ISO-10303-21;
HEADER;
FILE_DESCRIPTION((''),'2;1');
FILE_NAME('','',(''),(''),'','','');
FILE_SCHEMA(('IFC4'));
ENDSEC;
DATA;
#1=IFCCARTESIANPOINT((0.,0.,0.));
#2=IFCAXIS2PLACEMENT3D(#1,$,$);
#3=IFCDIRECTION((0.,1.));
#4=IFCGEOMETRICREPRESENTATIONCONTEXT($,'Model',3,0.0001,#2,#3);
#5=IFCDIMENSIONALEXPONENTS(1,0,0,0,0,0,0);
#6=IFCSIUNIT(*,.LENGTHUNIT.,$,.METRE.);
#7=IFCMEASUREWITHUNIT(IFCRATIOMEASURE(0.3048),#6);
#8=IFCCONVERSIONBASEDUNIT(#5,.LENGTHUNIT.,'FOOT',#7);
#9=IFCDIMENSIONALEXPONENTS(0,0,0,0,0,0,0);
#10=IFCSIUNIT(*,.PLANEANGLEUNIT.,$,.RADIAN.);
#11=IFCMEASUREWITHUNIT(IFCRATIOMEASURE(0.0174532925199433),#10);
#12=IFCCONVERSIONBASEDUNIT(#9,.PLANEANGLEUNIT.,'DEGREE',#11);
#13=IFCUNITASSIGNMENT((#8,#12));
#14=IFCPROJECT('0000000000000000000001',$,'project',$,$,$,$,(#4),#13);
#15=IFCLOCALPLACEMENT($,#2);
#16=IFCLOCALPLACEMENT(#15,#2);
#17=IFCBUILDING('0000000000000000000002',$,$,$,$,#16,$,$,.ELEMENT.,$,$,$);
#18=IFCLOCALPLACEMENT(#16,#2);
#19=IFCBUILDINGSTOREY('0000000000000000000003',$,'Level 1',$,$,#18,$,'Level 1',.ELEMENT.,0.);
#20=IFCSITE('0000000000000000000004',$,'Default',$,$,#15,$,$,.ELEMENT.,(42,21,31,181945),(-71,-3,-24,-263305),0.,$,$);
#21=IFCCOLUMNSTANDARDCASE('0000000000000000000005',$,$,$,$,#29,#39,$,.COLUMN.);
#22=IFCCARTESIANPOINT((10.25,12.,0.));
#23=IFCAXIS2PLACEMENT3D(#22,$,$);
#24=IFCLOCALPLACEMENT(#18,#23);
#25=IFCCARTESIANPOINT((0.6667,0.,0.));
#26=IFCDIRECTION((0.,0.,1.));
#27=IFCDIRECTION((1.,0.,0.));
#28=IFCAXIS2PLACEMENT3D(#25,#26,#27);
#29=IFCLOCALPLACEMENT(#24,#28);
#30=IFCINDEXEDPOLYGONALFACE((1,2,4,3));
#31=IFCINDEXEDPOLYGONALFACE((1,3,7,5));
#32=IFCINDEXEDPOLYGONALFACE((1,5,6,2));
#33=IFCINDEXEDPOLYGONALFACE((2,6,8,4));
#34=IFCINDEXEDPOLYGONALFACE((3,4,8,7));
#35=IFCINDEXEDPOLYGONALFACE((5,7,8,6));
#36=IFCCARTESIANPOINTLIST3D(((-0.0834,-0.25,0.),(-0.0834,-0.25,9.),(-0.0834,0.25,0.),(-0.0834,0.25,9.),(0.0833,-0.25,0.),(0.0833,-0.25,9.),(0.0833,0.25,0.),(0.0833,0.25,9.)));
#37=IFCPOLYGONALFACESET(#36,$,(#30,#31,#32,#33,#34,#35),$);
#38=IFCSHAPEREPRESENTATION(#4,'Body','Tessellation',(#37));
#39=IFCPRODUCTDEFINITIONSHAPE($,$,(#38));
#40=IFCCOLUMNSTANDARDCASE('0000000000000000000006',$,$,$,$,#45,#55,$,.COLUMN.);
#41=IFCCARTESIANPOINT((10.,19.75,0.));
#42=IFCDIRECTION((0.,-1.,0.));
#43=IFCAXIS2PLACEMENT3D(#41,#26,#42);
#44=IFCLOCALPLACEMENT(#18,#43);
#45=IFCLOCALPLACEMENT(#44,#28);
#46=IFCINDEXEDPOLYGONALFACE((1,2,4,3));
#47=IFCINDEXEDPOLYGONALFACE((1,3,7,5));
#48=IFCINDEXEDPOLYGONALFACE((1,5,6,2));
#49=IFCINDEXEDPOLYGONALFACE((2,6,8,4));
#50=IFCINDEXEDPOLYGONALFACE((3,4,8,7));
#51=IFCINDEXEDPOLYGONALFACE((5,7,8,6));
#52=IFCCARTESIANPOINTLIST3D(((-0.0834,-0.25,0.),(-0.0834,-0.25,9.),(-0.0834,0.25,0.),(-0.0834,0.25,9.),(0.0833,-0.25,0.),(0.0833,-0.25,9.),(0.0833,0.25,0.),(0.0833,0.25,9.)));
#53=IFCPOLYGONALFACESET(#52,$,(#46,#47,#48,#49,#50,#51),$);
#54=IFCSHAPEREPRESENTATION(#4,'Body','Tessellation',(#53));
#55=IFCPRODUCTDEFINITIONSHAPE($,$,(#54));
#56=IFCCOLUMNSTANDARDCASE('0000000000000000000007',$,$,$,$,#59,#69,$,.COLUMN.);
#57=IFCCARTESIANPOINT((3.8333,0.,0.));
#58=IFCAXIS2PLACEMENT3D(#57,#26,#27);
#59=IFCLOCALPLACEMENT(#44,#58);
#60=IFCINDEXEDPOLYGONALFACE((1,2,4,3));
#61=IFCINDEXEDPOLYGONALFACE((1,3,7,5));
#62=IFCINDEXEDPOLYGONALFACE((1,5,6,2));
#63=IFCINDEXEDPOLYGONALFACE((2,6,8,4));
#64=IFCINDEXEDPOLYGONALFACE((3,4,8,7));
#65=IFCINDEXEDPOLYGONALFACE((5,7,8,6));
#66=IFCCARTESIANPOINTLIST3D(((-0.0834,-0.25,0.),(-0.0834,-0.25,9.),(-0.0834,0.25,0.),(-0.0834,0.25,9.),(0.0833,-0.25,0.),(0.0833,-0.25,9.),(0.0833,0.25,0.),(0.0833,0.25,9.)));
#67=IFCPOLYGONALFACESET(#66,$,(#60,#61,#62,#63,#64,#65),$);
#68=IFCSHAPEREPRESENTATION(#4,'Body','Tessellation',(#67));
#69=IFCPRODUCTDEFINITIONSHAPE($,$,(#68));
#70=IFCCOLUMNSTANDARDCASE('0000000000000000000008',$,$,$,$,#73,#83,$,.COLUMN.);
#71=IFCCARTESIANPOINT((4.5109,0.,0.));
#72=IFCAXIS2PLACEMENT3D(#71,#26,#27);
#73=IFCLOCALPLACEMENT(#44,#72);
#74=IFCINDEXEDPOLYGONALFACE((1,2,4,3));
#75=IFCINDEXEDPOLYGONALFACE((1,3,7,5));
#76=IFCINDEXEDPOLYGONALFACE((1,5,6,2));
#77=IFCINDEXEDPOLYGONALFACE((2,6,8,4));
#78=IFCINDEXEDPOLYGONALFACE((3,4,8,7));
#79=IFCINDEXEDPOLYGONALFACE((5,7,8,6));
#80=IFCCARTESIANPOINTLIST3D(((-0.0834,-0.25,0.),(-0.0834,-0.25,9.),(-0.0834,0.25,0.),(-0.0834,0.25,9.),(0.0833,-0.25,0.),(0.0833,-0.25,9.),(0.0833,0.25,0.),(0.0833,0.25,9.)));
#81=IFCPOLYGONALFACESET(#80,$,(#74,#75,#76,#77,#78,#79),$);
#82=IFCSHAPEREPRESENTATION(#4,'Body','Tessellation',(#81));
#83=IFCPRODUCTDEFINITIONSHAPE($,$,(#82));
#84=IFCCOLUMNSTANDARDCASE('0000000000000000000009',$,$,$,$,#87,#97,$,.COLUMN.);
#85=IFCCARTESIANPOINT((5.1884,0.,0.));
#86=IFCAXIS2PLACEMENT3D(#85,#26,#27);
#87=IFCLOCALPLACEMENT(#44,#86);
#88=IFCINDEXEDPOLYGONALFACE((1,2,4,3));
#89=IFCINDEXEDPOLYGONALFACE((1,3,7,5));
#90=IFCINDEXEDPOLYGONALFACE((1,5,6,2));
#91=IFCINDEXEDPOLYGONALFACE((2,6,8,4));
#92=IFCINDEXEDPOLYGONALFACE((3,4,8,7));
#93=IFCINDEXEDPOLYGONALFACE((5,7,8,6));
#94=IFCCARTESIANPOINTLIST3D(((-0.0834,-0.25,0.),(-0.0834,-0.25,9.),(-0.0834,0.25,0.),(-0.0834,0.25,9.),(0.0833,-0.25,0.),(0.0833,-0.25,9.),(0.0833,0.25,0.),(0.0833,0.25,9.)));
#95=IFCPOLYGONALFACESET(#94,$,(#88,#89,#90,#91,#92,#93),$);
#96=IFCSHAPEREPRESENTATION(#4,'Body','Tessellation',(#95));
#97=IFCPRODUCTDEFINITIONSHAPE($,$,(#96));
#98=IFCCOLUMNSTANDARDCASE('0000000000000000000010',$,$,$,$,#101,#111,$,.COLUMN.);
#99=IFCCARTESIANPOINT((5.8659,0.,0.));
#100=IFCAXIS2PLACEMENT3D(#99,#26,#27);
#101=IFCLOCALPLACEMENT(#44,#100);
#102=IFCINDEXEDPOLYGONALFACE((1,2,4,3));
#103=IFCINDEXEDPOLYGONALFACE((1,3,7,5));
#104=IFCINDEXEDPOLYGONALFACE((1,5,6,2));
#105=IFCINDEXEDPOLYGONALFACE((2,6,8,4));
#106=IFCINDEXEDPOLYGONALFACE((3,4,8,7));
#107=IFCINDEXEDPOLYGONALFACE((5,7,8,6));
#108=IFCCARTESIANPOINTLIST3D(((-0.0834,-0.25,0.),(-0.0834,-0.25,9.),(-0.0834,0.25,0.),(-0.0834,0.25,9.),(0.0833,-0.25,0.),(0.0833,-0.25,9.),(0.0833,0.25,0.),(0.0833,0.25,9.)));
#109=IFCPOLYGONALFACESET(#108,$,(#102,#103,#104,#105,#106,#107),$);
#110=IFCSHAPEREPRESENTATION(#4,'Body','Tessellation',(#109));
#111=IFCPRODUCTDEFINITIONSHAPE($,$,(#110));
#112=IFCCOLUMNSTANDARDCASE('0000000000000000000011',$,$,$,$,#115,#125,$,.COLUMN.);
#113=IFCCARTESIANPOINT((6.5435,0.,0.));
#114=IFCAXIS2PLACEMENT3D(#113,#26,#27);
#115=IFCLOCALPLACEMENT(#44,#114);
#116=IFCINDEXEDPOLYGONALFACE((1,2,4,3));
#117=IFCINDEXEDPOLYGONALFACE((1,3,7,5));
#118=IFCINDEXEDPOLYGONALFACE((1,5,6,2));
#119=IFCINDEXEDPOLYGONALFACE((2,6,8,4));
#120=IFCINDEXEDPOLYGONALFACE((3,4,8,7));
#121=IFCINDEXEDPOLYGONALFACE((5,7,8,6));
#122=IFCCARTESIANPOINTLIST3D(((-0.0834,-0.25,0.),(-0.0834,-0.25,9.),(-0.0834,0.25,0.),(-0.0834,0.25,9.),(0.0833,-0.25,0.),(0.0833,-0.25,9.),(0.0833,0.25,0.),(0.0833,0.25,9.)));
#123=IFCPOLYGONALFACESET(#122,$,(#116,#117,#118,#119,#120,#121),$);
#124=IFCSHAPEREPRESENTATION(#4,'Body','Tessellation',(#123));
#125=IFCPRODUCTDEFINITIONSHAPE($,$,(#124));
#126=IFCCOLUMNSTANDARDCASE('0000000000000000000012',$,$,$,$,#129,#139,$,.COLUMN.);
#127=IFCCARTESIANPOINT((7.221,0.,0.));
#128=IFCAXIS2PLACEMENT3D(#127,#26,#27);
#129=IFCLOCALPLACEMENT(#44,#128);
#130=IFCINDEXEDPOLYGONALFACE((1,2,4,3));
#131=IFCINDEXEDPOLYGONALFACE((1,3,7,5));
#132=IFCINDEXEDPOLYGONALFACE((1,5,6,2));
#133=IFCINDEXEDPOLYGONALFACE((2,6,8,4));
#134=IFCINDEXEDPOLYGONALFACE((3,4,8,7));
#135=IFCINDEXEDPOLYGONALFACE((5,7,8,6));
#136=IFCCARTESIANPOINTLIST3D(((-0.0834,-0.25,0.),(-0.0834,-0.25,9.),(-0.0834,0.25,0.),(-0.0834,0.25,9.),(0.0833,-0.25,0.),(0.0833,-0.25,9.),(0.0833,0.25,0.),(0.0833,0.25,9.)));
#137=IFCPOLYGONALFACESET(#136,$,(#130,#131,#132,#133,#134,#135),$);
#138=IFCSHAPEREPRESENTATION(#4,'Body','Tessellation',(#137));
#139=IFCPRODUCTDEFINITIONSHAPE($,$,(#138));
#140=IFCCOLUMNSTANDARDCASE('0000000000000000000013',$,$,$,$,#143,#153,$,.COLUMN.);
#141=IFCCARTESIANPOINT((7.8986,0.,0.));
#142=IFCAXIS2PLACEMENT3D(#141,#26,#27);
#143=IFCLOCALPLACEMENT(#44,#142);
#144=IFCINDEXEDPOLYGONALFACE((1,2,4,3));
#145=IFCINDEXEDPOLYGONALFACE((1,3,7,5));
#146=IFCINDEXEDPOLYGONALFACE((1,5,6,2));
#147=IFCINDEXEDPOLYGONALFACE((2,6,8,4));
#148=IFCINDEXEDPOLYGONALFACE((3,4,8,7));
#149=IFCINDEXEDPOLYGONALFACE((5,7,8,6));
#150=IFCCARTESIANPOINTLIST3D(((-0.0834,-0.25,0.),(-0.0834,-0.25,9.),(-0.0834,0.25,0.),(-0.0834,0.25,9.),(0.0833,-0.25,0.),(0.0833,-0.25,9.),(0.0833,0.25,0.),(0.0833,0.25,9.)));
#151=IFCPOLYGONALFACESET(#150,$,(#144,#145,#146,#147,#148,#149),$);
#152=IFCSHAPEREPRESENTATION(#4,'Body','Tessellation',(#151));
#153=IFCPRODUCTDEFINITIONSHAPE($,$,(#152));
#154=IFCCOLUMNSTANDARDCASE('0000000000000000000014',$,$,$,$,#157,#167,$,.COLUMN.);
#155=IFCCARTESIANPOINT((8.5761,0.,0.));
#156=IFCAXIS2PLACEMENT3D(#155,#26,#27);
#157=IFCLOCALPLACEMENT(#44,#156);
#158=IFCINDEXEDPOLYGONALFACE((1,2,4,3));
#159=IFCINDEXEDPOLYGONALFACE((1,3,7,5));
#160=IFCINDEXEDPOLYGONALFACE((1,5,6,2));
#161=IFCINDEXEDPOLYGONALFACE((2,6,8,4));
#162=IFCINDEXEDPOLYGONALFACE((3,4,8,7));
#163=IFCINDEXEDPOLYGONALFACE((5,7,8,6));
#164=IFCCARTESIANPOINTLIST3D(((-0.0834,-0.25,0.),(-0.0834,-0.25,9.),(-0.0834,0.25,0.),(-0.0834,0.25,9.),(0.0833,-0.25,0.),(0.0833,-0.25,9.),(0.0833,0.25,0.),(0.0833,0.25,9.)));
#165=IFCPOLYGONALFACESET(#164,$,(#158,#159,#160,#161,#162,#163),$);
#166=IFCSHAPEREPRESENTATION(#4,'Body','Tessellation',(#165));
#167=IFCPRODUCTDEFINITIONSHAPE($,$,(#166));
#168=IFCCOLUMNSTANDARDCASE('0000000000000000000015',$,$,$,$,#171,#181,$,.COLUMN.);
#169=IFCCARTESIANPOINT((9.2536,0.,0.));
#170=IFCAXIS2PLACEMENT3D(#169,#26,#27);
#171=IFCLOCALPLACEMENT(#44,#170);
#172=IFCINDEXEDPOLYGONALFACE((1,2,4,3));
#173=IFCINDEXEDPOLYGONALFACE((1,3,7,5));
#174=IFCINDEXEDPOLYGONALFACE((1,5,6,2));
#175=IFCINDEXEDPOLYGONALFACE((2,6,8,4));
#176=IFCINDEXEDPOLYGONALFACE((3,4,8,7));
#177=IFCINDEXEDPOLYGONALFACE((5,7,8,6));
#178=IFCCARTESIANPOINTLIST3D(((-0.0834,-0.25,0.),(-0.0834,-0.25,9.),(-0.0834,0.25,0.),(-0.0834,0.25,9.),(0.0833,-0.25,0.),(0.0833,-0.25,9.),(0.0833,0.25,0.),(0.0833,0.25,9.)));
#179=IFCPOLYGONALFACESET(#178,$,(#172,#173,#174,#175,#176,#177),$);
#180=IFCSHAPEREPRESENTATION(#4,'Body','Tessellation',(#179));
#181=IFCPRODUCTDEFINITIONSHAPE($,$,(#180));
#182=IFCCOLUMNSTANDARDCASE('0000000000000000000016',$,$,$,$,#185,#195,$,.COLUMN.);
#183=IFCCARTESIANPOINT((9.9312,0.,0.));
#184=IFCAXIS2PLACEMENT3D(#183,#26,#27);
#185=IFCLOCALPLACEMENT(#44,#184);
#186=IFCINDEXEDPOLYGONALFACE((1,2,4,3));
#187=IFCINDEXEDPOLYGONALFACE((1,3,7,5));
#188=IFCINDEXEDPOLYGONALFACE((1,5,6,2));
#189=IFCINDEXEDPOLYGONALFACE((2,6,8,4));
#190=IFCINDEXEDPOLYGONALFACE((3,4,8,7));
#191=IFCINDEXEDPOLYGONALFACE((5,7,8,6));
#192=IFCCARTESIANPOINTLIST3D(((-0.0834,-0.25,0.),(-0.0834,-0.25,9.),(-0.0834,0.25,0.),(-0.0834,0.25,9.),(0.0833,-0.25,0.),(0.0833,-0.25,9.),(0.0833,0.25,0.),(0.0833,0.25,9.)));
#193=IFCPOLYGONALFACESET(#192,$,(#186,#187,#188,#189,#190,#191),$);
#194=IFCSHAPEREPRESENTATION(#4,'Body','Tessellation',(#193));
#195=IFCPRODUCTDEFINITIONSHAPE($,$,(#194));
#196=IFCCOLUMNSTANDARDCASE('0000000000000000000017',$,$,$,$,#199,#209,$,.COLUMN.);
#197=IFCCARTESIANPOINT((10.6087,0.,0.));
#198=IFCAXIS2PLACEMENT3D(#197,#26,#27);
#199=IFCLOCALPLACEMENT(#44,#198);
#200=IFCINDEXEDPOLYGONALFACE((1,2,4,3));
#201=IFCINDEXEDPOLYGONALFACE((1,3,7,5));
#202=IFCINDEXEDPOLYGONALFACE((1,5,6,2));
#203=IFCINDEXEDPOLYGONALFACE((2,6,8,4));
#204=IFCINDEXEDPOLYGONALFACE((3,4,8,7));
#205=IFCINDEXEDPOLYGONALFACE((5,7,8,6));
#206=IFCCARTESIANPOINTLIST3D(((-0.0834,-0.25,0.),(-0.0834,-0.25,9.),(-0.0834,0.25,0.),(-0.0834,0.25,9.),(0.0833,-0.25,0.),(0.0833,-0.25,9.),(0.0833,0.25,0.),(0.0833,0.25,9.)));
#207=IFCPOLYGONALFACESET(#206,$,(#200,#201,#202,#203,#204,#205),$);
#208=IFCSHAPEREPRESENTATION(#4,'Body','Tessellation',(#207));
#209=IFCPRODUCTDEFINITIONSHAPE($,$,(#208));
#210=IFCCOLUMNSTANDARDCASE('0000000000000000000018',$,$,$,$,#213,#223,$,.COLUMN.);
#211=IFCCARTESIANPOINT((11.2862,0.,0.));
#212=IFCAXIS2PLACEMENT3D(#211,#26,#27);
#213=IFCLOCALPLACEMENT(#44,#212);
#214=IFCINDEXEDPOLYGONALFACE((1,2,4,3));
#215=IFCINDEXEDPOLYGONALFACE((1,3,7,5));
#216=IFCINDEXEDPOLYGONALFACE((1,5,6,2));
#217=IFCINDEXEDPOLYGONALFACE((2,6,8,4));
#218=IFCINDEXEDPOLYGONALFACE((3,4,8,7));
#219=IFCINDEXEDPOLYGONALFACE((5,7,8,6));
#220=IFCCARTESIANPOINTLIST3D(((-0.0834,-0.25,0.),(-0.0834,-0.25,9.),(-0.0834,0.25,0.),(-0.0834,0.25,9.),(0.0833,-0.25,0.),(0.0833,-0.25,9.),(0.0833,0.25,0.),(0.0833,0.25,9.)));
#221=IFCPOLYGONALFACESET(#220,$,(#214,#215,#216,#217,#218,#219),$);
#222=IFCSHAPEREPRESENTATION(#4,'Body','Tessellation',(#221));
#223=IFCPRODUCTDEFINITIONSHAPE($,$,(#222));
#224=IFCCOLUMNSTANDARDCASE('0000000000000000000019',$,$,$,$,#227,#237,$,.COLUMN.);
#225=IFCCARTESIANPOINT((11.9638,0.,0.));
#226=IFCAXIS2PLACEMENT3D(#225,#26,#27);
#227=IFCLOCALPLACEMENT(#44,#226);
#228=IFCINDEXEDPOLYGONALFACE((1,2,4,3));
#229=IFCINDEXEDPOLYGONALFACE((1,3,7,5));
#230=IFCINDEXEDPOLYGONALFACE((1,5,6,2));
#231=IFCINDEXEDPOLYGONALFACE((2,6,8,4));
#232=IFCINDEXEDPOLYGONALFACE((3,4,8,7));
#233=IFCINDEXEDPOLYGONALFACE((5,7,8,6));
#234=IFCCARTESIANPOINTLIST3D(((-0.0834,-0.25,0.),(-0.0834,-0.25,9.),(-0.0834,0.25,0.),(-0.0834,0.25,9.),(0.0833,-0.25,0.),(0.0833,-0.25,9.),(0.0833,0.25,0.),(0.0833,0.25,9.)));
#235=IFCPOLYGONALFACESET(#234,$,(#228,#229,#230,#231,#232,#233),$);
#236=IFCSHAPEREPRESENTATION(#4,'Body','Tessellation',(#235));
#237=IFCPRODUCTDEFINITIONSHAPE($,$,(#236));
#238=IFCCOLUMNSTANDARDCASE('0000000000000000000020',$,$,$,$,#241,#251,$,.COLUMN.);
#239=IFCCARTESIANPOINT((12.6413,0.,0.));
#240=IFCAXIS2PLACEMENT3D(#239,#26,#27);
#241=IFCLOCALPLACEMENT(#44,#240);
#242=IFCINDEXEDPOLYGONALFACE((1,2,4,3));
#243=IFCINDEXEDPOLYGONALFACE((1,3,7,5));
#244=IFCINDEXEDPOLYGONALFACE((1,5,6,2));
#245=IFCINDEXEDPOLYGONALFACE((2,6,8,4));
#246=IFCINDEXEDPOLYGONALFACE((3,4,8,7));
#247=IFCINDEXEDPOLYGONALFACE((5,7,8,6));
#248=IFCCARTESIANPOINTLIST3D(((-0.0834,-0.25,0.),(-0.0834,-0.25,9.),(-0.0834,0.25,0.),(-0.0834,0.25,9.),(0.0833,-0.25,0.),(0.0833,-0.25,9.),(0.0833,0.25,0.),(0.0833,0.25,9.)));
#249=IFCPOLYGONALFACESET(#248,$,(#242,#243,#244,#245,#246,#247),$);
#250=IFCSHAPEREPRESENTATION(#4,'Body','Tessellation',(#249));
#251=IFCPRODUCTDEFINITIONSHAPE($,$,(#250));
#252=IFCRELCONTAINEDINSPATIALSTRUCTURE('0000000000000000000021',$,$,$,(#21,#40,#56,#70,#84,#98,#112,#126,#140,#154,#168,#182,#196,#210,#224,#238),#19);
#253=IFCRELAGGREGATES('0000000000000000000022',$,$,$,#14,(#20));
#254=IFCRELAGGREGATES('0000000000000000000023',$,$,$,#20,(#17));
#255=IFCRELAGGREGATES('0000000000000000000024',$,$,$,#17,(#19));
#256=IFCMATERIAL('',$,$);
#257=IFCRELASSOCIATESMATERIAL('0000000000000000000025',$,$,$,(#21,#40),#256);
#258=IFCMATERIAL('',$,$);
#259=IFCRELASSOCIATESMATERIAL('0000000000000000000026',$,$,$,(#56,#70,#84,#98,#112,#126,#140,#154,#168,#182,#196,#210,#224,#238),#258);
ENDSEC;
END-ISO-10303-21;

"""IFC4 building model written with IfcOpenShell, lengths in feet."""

from ifc_helpers import new_model, entity, si_unit, converted_unit, direction, frame, origin, place, context, project, spatial, rectangle, extrude, material, element, save


model = new_model("IFC4")

# Units and contexts
model_context = context("Model", 3, precision=0.0001, world=origin(), true_north=direction((0.0, 1.0)))
ifc_project = project(units=[converted_unit("LENGTHUNIT", "FOOT", entity("IfcRatioMeasure", 0.3048), si_unit("LENGTHUNIT", "METRE"), dimensions=[1, 0, 0, 0, 0, 0, 0]), converted_unit("PLANEANGLEUNIT", "DEGREE", entity("IfcRatioMeasure", 0.0174532925199433), si_unit("PLANEANGLEUNIT", "RADIAN"), dimensions=[0, 0, 0, 0, 0, 0, 0])], contexts=[model_context])

# Site, building, storey
site_placement = place(None, origin())
site = spatial("IfcSite", under=ifc_project, at=site_placement, Name="Default", CompositionType="ELEMENT", RefLatitude=(42, 21, 31, 181945), RefLongitude=(-71, -3, -24, -263305), RefElevation=0.0)
building_placement = place(site_placement, origin())
building = spatial("IfcBuilding", under=site, at=building_placement, CompositionType="ELEMENT")
storey_placement = place(building_placement, origin())
storey = spatial("IfcBuildingStorey", under=building, at=storey_placement, Name="Level 1", LongName="Level 1", CompositionType="ELEMENT", Elevation=0.0)

# Columns
ifc_material_1 = material(Name="")
placement_1 = place(storey_placement, frame((10.25, 12.0, 0.0)))
for number, where, z_axis, x_axis in (
    (1, (0.6667, 0.0, 0.0), (0.0, 0.0, 1.0), (1.0, 0.0, 0.0)),
):
    element("IfcColumnStandardCase", number, at=place(placement_1, frame(where, z_axis=z_axis, x_axis=x_axis)), inside=storey, material=ifc_material_1, PredefinedType="COLUMN", context=model_context, shape_type="SweptSolid", body=[
        extrude(rectangle(XDim=0.1667, YDim=0.5), origin(), (0.0, 0.0, 1.0), 9.0),
    ])
placement_2 = place(storey_placement, frame((10.0, 19.75, 0.0), z_axis=(0.0, 0.0, 1.0), x_axis=(0.0, -1.0, 0.0)))
for number, where, z_axis, x_axis in (
    (2, (0.6667, 0.0, 0.0), (0.0, 0.0, 1.0), (1.0, 0.0, 0.0)),
):
    element("IfcColumnStandardCase", number, at=place(placement_2, frame(where, z_axis=z_axis, x_axis=x_axis)), inside=storey, material=ifc_material_1, PredefinedType="COLUMN", context=model_context, shape_type="SweptSolid", body=[
        extrude(rectangle(XDim=0.1667, YDim=0.5), origin(), (0.0, 0.0, 1.0), 9.0),
    ])
ifc_material_2 = material(Name="")
for number, where, z_axis, x_axis in (
    (3, (3.8333, 0.0, 0.0), (0.0, 0.0, 1.0), (1.0, 0.0, 0.0)),
    (4, (4.5109, 0.0, 0.0), (0.0, 0.0, 1.0), (1.0, 0.0, 0.0)),
    (5, (5.1884, 0.0, 0.0), (0.0, 0.0, 1.0), (1.0, 0.0, 0.0)),
    (6, (5.8659, 0.0, 0.0), (0.0, 0.0, 1.0), (1.0, 0.0, 0.0)),
    (7, (6.5435, 0.0, 0.0), (0.0, 0.0, 1.0), (1.0, 0.0, 0.0)),
    (8, (7.221, 0.0, 0.0), (0.0, 0.0, 1.0), (1.0, 0.0, 0.0)),
    (9, (7.8986, 0.0, 0.0), (0.0, 0.0, 1.0), (1.0, 0.0, 0.0)),
    (10, (8.5761, 0.0, 0.0), (0.0, 0.0, 1.0), (1.0, 0.0, 0.0)),
    (11, (9.2536, 0.0, 0.0), (0.0, 0.0, 1.0), (1.0, 0.0, 0.0)),
    (12, (9.9312, 0.0, 0.0), (0.0, 0.0, 1.0), (1.0, 0.0, 0.0)),
    (13, (10.6087, 0.0, 0.0), (0.0, 0.0, 1.0), (1.0, 0.0, 0.0)),
    (14, (11.2862, 0.0, 0.0), (0.0, 0.0, 1.0), (1.0, 0.0, 0.0)),
    (15, (11.9638, 0.0, 0.0), (0.0, 0.0, 1.0), (1.0, 0.0, 0.0)),
    (16, (12.6413, 0.0, 0.0), (0.0, 0.0, 1.0), (1.0, 0.0, 0.0)),
):
    element("IfcColumnStandardCase", number, at=place(placement_2, frame(where, z_axis=z_axis, x_axis=x_axis)), inside=storey, material=ifc_material_2, PredefinedType="COLUMN", context=model_context, shape_type="SweptSolid", body=[
        extrude(rectangle(XDim=0.1667, YDim=0.5), origin(), (0.0, 0.0, 1.0), 9.0),
    ])

save(model, "model.ifc")
